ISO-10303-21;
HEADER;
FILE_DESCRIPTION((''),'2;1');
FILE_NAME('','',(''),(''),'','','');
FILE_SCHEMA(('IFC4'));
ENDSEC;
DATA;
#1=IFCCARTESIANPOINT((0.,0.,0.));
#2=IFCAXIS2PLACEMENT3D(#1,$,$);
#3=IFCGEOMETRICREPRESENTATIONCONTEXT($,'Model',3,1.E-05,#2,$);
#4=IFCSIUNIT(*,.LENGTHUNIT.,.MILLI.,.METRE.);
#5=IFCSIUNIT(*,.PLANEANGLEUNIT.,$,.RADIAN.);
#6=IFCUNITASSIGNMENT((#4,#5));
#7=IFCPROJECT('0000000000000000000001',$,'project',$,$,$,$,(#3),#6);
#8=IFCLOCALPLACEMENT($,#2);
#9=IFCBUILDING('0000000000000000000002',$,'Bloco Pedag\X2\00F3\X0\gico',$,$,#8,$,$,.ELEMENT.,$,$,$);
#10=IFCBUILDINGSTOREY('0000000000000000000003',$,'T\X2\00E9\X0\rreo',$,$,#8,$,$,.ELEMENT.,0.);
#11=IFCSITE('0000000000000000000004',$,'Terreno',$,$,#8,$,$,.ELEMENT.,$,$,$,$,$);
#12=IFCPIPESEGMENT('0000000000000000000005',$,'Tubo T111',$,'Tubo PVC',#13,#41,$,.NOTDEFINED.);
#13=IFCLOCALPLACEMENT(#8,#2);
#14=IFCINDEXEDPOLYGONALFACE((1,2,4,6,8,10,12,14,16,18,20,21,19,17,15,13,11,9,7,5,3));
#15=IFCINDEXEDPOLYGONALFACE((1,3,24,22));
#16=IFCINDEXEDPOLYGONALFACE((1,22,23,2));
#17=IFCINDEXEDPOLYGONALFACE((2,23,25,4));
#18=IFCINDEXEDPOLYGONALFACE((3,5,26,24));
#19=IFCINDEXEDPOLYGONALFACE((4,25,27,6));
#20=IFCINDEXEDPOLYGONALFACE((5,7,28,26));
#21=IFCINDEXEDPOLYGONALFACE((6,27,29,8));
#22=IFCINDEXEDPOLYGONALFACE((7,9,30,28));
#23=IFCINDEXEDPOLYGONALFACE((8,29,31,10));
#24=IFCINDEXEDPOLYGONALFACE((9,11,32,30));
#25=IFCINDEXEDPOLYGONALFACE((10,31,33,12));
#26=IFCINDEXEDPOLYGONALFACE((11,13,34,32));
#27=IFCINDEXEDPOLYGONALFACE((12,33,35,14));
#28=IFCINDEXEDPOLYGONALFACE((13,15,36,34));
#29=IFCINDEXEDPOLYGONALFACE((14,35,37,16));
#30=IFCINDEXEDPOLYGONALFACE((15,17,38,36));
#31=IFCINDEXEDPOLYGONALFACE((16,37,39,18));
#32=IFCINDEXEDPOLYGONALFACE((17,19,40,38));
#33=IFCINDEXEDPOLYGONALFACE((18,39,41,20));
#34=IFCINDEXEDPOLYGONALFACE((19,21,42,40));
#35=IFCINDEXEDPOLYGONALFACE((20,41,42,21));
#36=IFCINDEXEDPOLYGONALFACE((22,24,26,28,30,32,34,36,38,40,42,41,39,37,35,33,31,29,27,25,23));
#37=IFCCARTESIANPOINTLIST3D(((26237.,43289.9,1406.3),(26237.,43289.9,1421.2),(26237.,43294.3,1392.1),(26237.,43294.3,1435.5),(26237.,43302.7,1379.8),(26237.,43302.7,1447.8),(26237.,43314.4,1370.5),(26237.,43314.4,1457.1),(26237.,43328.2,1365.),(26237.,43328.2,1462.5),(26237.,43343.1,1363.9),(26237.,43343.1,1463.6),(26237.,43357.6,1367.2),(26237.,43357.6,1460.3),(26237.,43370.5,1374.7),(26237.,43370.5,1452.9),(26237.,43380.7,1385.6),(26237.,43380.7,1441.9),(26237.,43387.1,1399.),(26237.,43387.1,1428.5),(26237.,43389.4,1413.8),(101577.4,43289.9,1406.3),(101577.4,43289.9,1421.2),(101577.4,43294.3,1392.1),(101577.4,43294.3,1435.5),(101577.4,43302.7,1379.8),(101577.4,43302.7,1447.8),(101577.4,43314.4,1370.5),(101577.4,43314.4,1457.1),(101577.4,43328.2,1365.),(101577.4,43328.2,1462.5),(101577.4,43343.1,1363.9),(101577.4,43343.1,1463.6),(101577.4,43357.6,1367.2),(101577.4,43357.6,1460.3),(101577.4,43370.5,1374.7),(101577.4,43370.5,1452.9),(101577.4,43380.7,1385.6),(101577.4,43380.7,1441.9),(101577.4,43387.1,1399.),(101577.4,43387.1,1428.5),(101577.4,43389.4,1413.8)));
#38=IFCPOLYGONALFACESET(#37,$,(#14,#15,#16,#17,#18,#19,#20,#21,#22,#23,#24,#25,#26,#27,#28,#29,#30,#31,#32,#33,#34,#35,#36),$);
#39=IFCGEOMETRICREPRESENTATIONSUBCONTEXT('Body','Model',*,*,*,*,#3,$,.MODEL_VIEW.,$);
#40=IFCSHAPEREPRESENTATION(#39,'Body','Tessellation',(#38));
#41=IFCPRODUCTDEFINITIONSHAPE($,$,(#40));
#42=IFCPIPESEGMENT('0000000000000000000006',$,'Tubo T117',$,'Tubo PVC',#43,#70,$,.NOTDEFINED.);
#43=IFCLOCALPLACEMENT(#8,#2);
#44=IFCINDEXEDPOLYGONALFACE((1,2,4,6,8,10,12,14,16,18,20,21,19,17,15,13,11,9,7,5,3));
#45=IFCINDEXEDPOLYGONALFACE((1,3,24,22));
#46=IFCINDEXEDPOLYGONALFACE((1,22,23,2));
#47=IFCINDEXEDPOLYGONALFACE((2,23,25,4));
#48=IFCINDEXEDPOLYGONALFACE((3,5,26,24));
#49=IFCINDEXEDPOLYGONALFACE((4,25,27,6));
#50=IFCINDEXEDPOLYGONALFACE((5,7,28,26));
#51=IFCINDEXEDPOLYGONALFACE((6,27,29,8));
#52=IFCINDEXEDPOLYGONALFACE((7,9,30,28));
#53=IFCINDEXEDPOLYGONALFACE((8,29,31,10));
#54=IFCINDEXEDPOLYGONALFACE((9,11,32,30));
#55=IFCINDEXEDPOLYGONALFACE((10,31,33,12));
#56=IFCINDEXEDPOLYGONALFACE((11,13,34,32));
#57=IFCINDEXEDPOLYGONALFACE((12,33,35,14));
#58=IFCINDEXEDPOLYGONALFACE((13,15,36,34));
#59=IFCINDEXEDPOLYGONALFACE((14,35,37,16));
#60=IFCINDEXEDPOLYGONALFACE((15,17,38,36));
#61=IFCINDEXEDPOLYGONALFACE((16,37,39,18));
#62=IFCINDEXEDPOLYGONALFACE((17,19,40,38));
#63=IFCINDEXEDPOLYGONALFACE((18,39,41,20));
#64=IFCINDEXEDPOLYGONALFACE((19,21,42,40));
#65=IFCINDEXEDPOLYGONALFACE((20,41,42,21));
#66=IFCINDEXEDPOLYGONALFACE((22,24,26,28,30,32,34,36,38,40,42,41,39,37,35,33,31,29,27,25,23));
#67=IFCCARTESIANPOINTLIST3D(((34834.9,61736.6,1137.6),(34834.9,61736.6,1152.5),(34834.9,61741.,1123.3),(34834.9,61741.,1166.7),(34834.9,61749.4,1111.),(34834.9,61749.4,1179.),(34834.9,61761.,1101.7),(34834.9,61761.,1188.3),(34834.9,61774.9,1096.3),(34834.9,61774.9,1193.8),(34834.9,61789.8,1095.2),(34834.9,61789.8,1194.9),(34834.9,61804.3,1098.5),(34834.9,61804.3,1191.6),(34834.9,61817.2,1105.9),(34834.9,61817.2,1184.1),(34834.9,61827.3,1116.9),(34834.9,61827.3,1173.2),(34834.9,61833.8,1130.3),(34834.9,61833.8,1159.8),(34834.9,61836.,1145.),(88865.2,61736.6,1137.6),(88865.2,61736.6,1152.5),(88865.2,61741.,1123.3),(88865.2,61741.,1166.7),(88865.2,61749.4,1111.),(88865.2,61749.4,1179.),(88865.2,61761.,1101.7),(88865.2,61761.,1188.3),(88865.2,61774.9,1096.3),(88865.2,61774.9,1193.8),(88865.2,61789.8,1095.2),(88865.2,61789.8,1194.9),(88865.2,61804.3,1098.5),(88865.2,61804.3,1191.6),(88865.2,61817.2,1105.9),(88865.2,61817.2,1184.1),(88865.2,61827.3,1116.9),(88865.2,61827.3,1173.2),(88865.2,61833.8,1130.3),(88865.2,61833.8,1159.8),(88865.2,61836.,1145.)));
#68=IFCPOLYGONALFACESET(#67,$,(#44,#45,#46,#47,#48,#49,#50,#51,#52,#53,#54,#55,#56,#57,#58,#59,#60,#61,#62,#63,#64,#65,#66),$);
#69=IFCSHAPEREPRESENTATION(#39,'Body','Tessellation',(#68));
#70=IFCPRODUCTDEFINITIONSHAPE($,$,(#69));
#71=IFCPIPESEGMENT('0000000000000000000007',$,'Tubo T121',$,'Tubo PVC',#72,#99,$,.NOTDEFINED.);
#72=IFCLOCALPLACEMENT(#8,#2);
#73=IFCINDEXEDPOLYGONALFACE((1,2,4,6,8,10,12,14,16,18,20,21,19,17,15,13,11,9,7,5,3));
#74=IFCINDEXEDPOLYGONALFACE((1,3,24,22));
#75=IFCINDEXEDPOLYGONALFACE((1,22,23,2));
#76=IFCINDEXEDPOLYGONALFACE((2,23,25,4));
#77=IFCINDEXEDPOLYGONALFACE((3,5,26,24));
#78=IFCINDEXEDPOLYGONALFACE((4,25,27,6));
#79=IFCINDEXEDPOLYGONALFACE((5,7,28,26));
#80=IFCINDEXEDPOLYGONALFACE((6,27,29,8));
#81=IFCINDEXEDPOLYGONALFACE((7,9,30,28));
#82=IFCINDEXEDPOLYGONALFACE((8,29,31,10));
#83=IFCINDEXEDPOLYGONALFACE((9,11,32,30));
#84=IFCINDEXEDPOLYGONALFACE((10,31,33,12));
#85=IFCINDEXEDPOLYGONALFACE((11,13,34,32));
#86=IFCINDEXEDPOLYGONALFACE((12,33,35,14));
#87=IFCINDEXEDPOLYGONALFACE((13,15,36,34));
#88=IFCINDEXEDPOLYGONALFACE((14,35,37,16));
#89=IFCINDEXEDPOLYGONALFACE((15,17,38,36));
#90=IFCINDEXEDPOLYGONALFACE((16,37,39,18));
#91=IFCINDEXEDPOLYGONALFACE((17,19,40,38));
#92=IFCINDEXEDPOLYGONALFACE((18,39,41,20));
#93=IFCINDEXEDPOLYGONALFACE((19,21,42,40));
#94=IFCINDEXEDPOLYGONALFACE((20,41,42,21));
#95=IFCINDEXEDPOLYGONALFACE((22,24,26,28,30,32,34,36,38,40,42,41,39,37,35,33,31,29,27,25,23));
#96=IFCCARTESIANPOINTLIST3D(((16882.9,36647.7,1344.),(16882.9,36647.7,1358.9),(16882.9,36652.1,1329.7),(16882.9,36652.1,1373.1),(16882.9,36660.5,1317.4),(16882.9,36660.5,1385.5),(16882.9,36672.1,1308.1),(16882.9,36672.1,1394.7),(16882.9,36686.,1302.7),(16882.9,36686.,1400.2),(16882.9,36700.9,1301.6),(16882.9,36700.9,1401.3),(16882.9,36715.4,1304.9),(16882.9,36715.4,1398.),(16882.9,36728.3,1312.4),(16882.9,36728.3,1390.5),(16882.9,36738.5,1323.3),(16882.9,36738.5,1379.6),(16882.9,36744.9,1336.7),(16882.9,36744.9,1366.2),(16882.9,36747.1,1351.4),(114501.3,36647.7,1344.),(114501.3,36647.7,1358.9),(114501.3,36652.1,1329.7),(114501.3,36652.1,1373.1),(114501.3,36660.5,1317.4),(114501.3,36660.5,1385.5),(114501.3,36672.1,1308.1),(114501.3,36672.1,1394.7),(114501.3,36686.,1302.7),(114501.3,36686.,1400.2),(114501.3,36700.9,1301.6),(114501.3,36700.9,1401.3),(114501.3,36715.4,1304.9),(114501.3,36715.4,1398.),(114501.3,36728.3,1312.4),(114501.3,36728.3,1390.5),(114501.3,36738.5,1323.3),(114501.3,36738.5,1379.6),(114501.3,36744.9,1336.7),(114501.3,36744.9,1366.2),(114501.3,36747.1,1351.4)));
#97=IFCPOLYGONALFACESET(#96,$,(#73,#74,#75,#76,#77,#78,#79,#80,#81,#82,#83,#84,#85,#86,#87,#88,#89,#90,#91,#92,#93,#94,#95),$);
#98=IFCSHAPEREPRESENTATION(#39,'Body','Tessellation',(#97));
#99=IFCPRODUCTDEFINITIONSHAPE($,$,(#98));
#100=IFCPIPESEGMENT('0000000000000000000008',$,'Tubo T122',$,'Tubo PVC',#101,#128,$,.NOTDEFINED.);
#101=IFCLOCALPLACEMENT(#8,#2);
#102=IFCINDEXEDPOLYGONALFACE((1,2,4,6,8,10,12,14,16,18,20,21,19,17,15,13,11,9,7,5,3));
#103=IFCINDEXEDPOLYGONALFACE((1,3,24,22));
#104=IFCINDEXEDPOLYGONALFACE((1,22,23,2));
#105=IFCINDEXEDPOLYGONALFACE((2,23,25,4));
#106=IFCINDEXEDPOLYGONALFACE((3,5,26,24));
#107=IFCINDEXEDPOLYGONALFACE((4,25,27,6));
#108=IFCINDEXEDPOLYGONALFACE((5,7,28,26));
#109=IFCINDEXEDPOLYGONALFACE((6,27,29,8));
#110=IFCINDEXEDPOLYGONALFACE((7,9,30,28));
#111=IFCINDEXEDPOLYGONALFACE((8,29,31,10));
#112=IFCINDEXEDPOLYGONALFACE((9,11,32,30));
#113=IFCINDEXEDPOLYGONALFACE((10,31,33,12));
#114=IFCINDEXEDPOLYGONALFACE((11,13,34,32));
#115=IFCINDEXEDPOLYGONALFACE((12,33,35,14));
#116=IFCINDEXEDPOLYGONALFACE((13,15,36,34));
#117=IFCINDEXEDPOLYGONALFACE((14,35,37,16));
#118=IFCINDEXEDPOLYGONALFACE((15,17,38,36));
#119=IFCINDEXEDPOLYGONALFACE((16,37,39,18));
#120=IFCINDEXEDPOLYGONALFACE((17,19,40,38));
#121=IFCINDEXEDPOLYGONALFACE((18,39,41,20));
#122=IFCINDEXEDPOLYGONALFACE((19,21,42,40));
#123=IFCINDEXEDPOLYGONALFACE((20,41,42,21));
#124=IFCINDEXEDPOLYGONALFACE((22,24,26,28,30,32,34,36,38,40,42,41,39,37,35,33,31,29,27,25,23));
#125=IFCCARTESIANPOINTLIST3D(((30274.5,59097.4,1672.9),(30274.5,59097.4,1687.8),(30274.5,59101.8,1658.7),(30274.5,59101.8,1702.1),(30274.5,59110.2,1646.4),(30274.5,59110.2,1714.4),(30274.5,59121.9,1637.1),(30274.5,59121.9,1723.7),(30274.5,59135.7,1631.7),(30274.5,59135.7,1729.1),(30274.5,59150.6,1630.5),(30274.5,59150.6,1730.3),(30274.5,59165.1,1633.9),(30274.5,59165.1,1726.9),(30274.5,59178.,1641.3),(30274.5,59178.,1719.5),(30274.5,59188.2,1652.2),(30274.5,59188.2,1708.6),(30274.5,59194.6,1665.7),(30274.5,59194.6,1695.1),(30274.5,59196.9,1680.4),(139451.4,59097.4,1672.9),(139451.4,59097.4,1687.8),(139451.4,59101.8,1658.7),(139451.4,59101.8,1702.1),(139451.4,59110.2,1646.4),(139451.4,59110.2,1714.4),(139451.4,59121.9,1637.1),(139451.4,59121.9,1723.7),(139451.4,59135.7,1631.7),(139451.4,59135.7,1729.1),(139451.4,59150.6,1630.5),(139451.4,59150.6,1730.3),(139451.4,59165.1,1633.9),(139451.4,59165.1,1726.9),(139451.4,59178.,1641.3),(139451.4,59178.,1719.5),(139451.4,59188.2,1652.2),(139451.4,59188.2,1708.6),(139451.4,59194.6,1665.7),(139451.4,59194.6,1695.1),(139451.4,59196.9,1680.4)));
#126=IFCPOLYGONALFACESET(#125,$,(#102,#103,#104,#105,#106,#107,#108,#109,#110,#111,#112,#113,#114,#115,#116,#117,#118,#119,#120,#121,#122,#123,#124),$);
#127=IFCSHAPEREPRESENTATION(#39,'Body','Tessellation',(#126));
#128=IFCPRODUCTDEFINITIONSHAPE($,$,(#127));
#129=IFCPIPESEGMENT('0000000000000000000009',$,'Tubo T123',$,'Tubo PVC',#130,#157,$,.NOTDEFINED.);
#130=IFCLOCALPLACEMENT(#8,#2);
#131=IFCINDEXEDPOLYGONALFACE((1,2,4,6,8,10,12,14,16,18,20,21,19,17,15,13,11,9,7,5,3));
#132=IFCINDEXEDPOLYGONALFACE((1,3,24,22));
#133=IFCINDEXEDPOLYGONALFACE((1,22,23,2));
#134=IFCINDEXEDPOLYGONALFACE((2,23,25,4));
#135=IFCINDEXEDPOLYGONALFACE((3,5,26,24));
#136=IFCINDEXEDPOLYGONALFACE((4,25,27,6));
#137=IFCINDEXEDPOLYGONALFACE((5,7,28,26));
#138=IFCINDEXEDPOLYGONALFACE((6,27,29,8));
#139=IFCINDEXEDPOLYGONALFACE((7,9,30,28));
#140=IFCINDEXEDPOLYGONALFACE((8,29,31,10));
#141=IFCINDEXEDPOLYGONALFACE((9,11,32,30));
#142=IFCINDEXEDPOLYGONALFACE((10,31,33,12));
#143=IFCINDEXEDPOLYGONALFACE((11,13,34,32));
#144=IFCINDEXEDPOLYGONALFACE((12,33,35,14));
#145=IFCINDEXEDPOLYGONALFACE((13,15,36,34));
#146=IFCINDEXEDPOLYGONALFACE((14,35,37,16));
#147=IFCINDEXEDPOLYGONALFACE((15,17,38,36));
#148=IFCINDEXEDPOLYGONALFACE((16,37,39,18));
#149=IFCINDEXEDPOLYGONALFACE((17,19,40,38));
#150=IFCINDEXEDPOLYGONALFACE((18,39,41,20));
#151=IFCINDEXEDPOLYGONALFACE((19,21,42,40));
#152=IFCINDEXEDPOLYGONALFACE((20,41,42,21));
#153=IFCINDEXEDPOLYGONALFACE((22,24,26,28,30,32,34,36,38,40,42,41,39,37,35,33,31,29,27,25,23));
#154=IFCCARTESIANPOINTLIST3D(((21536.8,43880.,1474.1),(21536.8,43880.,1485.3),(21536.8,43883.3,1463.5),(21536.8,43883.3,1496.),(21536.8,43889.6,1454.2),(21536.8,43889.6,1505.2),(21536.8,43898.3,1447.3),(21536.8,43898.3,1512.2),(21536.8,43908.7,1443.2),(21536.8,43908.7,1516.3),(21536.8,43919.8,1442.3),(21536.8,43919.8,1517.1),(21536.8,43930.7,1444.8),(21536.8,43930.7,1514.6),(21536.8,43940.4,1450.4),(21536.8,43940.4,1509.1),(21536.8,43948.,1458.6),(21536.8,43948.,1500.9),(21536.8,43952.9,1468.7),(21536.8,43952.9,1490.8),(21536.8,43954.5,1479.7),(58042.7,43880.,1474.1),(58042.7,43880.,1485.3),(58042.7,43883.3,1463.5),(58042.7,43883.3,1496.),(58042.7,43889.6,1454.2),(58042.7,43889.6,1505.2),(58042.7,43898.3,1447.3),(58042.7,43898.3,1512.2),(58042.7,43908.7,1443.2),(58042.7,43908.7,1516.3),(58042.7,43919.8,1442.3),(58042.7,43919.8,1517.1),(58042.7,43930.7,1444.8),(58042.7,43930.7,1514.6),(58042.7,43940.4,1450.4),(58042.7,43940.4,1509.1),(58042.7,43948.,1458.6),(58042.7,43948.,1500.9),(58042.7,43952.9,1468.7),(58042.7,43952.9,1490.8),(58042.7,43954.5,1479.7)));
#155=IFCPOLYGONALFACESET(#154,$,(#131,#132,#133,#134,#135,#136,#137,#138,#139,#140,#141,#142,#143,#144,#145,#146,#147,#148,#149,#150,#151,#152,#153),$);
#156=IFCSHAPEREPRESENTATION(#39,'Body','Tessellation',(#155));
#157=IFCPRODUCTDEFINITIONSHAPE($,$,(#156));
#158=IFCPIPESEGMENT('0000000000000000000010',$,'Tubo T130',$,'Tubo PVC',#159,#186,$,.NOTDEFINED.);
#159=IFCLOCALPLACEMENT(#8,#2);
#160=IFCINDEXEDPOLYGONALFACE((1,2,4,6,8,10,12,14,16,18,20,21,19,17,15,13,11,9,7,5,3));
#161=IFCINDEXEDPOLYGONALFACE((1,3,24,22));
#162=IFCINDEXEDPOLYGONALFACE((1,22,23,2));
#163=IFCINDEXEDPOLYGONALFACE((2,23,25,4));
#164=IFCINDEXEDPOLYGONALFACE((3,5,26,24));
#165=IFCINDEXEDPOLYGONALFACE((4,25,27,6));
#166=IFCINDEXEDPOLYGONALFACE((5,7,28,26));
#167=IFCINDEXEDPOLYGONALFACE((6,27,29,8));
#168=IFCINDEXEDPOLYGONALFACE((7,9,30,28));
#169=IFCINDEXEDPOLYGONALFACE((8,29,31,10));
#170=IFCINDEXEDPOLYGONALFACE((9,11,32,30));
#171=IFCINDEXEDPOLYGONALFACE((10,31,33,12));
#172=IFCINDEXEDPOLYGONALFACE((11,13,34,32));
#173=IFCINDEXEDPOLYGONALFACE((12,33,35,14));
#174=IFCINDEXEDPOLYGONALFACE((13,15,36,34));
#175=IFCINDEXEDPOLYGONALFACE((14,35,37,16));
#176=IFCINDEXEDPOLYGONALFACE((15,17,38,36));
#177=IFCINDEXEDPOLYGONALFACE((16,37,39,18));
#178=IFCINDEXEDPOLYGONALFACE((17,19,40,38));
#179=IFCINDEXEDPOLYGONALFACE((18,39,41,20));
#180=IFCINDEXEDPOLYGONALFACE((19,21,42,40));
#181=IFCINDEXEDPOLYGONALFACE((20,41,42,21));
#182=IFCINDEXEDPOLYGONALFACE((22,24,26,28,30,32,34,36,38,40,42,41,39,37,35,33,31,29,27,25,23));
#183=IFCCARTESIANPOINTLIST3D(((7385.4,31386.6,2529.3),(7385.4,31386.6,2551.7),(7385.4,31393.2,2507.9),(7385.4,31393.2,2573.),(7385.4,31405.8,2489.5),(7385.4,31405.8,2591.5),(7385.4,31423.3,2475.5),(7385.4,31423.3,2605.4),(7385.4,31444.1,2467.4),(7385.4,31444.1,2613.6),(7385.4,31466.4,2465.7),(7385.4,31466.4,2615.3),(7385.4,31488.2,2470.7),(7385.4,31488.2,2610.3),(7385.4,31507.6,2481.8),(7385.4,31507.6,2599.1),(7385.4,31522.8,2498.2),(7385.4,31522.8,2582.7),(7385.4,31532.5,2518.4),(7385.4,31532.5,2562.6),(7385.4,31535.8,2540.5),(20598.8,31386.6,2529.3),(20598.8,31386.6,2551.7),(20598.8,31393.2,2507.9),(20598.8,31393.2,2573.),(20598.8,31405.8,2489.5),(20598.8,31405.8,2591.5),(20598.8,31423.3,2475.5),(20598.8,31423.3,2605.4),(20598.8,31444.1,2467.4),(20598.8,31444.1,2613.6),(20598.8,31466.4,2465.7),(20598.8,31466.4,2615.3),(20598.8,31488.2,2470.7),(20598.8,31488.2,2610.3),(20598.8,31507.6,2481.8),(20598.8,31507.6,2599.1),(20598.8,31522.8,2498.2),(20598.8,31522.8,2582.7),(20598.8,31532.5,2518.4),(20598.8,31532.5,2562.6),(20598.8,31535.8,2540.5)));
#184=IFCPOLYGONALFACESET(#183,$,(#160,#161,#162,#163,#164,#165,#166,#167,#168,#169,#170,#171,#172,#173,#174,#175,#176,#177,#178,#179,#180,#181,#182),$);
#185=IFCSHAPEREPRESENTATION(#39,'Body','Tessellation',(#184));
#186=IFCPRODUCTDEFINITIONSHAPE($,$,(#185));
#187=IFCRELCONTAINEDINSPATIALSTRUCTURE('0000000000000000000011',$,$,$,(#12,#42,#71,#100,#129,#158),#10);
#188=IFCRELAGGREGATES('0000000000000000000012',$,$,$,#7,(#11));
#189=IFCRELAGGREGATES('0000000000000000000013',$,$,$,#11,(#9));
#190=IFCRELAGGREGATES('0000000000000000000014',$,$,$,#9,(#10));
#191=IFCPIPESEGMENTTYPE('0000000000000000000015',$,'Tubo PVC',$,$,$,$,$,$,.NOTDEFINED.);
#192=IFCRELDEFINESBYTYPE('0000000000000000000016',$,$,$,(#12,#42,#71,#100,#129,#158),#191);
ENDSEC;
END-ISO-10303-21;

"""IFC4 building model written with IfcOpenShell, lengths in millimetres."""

from ifc_helpers import new_model, si_unit, frame, origin, origin_2d, place, context, subcontext, project, spatial, circle, extrude, type_object, element, save


model = new_model("IFC4")

# Units and contexts
model_context = context("Model", 3, precision=1e-05, world=origin())
body_context = subcontext(model_context, "Body", "Model", "MODEL_VIEW")
ifc_project = project(units=[si_unit("LENGTHUNIT", "METRE", prefix="MILLI"), si_unit("PLANEANGLEUNIT", "RADIAN")], contexts=[model_context])

# Site, building, storey
placement = place(None, origin())
site = spatial("IfcSite", under=ifc_project, at=placement, Name="Terreno", CompositionType="ELEMENT")
building = spatial("IfcBuilding", under=site, at=placement, Name="Bloco Pedagógico", CompositionType="ELEMENT")
storey = spatial("IfcBuildingStorey", under=building, at=placement, Name="Térreo", CompositionType="ELEMENT", Elevation=0.0)

# Pipe segments
pipe_segment_type = type_object("IfcPipeSegmentType", Name="Tubo PVC", PredefinedType="NOTDEFINED")
pipe_segment_1_placement = place(None, frame((26237.0, 43339.4, 1413.8), z_axis=(1.0, 0.0, 0.0), x_axis=(0.0, 1.0, 0.0)))
element("IfcPipeSegment", 1, at=pipe_segment_1_placement, inside=storey, type_object=pipe_segment_type, Name="Tubo T111", ObjectType="Tubo PVC", PredefinedType="NOTDEFINED", context=body_context, shape_type="SweptSolid", body=[
    extrude(circle(Radius=50.0, at=origin_2d()), None, (0.0, 0.0, 1.0), 75340.5),
])
pipe_segment_2_placement = place(None, frame((34834.9, 61786.0, 1145.0), z_axis=(1.0, 0.0, 0.0), x_axis=(0.0, 1.0, 0.0)))
element("IfcPipeSegment", 2, at=pipe_segment_2_placement, inside=storey, type_object=pipe_segment_type, Name="Tubo T117", ObjectType="Tubo PVC", PredefinedType="NOTDEFINED", context=body_context, shape_type="SweptSolid", body=[
    extrude(circle(Radius=50.0, at=origin_2d()), None, (0.0, 0.0, 1.0), 54030.3),
])
pipe_segment_3_placement = place(None, frame((16882.9, 36697.1, 1351.4), z_axis=(1.0, 0.0, 0.0), x_axis=(0.0, 1.0, 0.0)))
element("IfcPipeSegment", 3, at=pipe_segment_3_placement, inside=storey, type_object=pipe_segment_type, Name="Tubo T121", ObjectType="Tubo PVC", PredefinedType="NOTDEFINED", context=body_context, shape_type="SweptSolid", body=[
    extrude(circle(Radius=50.0, at=origin_2d()), None, (0.0, 0.0, 1.0), 97618.4),
])
pipe_segment_4_placement = place(None, frame((30274.5, 59146.9, 1680.4), z_axis=(1.0, 0.0, 0.0), x_axis=(0.0, 1.0, 0.0)))
element("IfcPipeSegment", 4, at=pipe_segment_4_placement, inside=storey, type_object=pipe_segment_type, Name="Tubo T122", ObjectType="Tubo PVC", PredefinedType="NOTDEFINED", context=body_context, shape_type="SweptSolid", body=[
    extrude(circle(Radius=50.0, at=origin_2d()), None, (0.0, 0.0, 1.0), 109176.9),
])
pipe_segment_5_placement = place(None, frame((21536.8, 43917.0, 1479.7), z_axis=(1.0, 0.0, 0.0), x_axis=(0.0, 1.0, 0.0)))
element("IfcPipeSegment", 5, at=pipe_segment_5_placement, inside=storey, type_object=pipe_segment_type, Name="Tubo T123", ObjectType="Tubo PVC", PredefinedType="NOTDEFINED", context=body_context, shape_type="SweptSolid", body=[
    extrude(circle(Radius=37.5, at=origin_2d()), None, (0.0, 0.0, 1.0), 36505.9),
])
pipe_segment_6_placement = place(None, frame((7385.4, 31460.8, 2540.5), z_axis=(1.0, 0.0, 0.0), x_axis=(0.0, 1.0, 0.0)))
element("IfcPipeSegment", 6, at=pipe_segment_6_placement, inside=storey, type_object=pipe_segment_type, Name="Tubo T130", ObjectType="Tubo PVC", PredefinedType="NOTDEFINED", context=body_context, shape_type="SweptSolid", body=[
    extrude(circle(Radius=75.0, at=origin_2d()), None, (0.0, 0.0, 1.0), 13213.4),
])

save(model, "model.ifc")
